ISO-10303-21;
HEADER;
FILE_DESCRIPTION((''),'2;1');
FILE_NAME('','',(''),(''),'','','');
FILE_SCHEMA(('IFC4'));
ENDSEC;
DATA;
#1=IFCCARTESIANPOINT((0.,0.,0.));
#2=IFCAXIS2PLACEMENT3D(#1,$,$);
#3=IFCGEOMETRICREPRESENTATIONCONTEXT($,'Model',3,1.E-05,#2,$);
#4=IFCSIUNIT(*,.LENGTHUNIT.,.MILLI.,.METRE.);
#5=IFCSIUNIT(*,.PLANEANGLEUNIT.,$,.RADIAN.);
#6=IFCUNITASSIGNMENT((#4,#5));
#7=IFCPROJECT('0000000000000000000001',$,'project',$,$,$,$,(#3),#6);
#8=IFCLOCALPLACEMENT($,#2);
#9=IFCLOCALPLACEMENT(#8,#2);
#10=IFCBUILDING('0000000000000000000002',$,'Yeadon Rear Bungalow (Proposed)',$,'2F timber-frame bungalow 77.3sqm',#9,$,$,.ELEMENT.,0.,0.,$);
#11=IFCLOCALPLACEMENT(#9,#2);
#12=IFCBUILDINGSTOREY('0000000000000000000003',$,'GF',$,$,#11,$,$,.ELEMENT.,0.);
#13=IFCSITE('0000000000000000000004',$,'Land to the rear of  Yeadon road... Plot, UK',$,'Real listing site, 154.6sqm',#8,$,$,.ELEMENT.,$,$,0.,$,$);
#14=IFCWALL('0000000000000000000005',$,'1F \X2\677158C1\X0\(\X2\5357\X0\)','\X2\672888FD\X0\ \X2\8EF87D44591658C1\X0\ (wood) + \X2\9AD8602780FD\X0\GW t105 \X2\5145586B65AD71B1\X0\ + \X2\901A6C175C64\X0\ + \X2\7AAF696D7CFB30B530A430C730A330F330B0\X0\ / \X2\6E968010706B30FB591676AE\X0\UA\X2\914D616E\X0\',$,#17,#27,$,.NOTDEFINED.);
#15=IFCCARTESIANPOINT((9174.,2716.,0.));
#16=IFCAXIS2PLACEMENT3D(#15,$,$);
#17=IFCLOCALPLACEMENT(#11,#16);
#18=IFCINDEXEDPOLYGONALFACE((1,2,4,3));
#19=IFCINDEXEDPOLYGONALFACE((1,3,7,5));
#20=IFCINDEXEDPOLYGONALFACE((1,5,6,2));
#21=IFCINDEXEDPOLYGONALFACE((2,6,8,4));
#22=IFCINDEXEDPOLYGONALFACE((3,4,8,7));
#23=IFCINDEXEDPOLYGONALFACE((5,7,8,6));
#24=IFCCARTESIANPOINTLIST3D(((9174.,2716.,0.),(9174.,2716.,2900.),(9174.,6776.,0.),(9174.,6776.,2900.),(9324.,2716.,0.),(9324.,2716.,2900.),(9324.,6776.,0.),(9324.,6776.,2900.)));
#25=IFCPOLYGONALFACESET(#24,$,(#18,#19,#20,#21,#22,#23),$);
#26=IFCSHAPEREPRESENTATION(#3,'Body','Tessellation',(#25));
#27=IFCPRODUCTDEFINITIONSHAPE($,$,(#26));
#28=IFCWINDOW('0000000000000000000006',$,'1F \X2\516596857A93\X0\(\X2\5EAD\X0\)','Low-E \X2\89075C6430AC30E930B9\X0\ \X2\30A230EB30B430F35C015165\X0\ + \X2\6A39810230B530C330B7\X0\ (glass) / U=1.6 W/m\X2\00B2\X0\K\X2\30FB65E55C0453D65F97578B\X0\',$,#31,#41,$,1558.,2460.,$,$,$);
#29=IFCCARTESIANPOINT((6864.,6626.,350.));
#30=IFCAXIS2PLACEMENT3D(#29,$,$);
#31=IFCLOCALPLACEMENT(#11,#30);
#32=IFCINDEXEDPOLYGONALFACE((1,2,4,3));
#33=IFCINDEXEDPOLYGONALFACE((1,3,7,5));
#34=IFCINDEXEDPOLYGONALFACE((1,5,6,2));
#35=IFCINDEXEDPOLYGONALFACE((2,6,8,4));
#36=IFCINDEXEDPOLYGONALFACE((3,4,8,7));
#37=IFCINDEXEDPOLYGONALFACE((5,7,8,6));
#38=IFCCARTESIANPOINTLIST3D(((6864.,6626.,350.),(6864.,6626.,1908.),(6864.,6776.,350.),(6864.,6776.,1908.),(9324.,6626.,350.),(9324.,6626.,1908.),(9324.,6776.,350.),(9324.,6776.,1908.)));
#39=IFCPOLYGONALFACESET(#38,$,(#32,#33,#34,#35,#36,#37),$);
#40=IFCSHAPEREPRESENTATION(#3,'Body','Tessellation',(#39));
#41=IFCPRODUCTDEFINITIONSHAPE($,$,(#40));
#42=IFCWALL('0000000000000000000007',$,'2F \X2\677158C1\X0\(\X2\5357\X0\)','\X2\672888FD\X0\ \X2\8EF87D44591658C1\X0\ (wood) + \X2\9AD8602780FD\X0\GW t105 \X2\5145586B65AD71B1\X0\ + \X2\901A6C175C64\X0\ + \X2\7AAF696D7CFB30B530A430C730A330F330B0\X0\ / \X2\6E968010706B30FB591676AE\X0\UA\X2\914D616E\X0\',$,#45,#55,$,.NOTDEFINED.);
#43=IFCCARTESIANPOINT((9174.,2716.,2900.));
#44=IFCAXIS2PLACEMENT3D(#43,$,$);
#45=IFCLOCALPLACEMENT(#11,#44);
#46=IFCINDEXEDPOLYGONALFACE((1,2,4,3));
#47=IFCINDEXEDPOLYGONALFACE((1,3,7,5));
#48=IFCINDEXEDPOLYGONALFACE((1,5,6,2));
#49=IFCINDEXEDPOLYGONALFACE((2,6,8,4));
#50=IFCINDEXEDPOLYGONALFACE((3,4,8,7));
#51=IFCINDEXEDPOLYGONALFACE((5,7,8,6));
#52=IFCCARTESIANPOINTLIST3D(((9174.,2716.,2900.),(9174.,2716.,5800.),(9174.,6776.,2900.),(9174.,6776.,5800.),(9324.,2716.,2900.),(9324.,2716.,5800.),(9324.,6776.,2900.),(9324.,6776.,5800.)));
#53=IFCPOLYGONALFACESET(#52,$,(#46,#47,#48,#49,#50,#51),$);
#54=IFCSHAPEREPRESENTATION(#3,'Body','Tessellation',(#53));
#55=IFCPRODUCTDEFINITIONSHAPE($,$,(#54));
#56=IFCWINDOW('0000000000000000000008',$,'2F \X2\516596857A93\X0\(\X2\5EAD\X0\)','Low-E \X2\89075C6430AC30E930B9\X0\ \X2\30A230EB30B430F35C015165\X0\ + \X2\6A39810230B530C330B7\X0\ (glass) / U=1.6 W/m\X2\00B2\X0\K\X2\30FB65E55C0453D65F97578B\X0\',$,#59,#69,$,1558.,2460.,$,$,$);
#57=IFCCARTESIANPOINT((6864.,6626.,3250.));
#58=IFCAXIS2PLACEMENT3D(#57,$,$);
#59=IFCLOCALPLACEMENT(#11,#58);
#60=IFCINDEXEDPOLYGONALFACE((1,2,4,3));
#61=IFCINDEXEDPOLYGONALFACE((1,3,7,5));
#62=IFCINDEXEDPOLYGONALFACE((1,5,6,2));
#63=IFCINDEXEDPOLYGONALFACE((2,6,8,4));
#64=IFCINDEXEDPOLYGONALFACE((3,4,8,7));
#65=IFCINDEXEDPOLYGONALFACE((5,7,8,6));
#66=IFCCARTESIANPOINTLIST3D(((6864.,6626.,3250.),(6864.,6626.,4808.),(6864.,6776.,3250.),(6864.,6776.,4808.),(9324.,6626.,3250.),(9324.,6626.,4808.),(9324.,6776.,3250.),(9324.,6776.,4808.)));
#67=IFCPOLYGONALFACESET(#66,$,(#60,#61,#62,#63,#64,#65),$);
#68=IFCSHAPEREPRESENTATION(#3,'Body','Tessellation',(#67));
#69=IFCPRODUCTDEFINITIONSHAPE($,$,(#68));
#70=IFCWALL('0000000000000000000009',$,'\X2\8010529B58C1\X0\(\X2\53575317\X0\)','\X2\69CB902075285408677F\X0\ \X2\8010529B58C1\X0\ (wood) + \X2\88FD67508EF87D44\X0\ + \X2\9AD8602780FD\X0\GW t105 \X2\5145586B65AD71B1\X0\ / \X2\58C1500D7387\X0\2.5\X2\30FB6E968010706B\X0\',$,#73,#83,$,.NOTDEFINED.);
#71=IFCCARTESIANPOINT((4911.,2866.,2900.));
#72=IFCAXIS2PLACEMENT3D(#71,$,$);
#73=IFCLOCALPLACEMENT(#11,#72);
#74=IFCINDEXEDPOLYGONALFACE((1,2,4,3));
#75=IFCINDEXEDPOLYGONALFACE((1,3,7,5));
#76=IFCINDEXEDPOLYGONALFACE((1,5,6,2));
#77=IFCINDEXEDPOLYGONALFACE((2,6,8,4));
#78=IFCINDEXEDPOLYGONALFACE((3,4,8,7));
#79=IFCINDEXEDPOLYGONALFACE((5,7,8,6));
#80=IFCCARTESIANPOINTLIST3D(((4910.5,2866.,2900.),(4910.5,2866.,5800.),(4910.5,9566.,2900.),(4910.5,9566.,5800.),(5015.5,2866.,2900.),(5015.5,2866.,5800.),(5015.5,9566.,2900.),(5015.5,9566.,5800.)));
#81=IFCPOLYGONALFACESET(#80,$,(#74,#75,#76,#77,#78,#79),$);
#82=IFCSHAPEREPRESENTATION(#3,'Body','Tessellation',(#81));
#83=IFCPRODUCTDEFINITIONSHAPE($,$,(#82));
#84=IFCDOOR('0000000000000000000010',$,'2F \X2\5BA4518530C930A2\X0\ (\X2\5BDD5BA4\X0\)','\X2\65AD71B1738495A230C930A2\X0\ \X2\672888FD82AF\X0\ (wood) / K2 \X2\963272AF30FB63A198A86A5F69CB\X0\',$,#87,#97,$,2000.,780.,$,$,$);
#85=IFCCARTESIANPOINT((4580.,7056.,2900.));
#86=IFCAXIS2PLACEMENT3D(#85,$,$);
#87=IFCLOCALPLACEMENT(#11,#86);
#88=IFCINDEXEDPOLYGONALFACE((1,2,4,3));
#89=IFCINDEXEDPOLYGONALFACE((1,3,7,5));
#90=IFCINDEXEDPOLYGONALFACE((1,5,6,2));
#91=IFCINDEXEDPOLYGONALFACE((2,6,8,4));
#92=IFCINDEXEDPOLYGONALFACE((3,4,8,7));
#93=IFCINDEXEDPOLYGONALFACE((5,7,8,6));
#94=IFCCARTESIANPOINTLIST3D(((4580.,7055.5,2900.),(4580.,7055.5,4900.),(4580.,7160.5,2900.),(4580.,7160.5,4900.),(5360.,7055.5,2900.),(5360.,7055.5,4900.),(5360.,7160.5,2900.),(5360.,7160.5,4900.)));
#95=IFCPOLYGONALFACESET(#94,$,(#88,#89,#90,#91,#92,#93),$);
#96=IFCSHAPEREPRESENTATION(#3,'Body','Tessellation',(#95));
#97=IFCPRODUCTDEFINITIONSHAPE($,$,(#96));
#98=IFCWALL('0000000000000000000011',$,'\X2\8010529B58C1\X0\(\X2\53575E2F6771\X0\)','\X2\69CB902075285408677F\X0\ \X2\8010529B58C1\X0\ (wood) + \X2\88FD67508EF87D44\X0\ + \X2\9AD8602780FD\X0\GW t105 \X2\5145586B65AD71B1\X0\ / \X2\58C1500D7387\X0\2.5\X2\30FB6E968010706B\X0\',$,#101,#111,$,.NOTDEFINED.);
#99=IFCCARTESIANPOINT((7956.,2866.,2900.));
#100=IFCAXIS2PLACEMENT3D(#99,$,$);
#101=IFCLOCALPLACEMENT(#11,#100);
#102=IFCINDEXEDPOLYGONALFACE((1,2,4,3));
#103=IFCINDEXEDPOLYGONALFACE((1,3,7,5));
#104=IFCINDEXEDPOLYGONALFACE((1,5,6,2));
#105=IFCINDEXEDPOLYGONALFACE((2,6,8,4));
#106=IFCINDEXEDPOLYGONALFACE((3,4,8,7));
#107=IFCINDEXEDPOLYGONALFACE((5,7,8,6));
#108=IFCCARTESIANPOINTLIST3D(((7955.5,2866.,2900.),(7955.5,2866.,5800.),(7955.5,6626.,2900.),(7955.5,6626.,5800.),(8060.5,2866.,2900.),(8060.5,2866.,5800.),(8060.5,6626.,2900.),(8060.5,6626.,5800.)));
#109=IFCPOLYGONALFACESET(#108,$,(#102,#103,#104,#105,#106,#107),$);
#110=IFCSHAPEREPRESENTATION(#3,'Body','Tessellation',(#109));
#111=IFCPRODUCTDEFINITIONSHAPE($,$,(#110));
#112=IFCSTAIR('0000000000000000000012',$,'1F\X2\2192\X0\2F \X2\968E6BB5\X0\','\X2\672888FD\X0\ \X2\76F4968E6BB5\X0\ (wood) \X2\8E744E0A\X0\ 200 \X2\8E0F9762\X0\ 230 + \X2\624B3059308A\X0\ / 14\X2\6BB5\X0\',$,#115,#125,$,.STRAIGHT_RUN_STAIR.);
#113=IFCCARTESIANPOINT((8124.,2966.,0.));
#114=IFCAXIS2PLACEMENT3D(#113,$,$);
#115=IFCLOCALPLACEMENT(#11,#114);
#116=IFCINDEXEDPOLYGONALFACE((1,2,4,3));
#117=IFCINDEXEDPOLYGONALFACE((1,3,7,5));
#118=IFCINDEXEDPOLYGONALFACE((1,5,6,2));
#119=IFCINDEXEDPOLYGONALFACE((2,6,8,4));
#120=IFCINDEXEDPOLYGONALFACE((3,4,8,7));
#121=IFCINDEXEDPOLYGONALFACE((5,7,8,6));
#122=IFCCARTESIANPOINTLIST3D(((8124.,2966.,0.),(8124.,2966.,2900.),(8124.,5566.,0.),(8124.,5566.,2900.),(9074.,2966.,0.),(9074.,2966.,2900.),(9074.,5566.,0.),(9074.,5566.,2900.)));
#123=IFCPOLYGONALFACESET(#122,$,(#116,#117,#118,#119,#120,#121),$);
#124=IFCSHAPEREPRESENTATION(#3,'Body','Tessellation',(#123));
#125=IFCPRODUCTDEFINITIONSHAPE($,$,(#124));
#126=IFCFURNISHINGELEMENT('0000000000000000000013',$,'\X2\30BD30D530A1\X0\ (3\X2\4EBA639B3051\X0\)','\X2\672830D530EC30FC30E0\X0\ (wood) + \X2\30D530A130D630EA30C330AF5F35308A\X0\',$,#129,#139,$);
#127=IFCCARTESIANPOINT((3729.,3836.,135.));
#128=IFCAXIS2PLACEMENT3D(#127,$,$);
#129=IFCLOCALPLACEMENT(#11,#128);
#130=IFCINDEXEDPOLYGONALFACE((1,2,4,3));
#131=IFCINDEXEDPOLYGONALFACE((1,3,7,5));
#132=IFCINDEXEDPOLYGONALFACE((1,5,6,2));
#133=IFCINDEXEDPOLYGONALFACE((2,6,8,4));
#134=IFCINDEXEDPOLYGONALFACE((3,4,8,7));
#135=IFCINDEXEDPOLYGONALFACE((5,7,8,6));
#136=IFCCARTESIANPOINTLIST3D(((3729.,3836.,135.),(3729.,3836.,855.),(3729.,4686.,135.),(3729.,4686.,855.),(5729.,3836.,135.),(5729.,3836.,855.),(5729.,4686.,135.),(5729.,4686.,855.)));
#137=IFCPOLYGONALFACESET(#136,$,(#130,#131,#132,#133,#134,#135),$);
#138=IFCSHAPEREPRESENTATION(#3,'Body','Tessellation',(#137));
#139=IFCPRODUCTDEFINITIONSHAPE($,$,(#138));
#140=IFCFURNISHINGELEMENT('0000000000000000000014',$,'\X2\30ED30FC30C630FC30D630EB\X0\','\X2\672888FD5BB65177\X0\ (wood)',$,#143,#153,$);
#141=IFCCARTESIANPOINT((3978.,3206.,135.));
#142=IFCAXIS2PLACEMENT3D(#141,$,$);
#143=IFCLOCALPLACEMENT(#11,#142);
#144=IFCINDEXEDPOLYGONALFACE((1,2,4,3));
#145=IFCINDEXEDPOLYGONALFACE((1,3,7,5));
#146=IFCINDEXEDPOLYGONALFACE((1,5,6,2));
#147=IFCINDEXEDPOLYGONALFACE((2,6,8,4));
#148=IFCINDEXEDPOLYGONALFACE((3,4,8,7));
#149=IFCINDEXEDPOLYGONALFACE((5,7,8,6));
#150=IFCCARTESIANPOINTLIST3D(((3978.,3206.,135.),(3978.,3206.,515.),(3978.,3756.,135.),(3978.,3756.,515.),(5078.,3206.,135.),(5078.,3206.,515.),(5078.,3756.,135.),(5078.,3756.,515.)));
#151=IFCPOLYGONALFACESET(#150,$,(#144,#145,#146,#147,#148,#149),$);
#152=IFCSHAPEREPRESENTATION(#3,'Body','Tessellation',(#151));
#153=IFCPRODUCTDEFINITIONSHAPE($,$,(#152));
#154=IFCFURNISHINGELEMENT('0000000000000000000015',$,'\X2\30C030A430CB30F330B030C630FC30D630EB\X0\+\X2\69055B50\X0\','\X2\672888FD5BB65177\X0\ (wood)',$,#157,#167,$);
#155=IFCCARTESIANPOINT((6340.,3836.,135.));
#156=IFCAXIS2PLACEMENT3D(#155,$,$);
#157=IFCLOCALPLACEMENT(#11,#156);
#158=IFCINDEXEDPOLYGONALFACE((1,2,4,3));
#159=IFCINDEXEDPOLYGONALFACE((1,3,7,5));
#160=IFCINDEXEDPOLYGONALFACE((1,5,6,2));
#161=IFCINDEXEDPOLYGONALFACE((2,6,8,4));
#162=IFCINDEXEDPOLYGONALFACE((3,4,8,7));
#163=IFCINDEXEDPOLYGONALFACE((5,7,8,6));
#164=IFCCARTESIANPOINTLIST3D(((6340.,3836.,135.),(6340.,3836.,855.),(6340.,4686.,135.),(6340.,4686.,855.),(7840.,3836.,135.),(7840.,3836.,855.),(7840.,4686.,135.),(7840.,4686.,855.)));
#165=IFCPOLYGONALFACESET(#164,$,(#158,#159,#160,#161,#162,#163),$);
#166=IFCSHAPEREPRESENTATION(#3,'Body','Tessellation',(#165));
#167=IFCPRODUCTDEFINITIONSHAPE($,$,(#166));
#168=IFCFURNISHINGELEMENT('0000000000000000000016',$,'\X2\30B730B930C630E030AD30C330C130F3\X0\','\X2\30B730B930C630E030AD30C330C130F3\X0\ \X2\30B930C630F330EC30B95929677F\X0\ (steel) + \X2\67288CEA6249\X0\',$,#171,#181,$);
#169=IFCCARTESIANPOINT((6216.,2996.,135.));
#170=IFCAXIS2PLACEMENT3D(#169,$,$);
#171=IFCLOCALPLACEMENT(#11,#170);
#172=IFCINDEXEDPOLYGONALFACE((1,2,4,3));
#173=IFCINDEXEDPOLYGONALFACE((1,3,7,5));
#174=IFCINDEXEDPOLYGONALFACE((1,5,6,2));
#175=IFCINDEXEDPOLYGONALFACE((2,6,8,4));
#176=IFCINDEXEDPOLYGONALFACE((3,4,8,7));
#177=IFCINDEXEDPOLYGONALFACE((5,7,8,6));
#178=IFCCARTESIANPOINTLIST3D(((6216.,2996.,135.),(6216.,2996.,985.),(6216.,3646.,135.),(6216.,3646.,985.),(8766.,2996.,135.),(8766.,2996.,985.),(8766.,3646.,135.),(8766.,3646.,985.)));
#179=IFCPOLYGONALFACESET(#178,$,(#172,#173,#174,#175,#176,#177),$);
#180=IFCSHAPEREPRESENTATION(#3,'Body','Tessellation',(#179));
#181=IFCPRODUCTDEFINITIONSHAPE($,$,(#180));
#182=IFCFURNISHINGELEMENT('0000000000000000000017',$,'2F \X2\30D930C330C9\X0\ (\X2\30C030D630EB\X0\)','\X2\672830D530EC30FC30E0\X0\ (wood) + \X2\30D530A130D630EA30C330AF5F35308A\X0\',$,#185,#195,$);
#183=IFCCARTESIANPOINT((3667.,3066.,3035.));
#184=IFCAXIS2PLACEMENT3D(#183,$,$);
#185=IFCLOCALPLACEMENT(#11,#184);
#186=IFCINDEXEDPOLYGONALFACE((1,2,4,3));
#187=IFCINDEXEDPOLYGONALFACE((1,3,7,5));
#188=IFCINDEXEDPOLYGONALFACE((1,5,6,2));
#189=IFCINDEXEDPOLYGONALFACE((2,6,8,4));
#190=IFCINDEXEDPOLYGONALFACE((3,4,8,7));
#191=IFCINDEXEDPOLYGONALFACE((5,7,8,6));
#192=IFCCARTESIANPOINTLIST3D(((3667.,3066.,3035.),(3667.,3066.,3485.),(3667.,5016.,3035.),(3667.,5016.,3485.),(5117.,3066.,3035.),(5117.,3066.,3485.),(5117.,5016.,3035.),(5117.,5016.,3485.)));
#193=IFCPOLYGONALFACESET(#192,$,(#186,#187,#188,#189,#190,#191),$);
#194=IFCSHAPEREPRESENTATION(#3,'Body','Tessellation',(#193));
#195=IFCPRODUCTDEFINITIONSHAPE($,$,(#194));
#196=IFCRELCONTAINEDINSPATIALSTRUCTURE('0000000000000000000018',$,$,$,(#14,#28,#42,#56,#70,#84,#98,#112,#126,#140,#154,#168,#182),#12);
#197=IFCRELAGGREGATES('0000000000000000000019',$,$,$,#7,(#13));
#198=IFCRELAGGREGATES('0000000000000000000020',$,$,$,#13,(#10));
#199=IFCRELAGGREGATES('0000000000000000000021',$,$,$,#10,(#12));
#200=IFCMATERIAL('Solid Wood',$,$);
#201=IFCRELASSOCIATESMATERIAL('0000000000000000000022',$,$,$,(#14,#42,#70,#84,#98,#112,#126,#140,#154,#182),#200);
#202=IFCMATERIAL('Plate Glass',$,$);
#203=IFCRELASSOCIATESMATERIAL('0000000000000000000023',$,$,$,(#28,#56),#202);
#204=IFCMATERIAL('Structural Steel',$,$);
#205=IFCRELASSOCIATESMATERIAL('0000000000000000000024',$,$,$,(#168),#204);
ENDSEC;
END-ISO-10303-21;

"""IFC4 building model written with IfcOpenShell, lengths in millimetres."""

from ifc_helpers import new_model, si_unit, frame, frame_2d, origin, place, context, project, spatial, rectangle, extrude, material, element, fill, save


model = new_model("IFC4")

# Units and contexts
model_context = context("Model", 3, precision=1e-05, world=origin())
ifc_project = project(units=[si_unit("LENGTHUNIT", "METRE", prefix="MILLI"), si_unit("PLANEANGLEUNIT", "RADIAN")], contexts=[model_context])

# Site, building, storey
site_placement = place(None, origin())
site = spatial("IfcSite", under=ifc_project, at=site_placement, Name="Land to the rear of  Yeadon road... Plot, UK", ObjectType="Real listing site, 154.6sqm", CompositionType="ELEMENT", RefElevation=0.0)
building_placement = place(site_placement, origin())
building = spatial("IfcBuilding", under=site, at=building_placement, Name="Yeadon Rear Bungalow (Proposed)", ObjectType="2F timber-frame bungalow 77.3sqm", CompositionType="ELEMENT", ElevationOfRefHeight=0.0, ElevationOfTerrain=0.0)
storey_placement = place(building_placement, origin())
storey = spatial("IfcBuildingStorey", under=building, at=storey_placement, Name="GF", CompositionType="ELEMENT", Elevation=0.0)

# Wall, opening, window
ifc_material_1 = material(Name="Solid Wood")
wall_1_placement = place(storey_placement, frame((9174.0, 2716.0, 0.0)))
wall_1 = element("IfcWall", 1, at=wall_1_placement, inside=storey, material=ifc_material_1, Name="1F 東壁(南)", Description="木製 軸組外壁 (wood) + 高性能GW t105 充填断熱 + 通気層 + 窯業系サイディング / 準耐火・外皮UA配慮", PredefinedType="NOTDEFINED", context=model_context, shape_type="SweptSolid", body=[
    extrude(rectangle(XDim=150.0, YDim=4060.0, at=frame_2d((75.0, 2030.0))), frame((9174.0, 2716.0, 0.0)), (0.0, 0.0, 1.0), 2900.0),
])
opening_1_placement = place(storey_placement, frame((6864.0, 6626.0, 350.0)))
opening_1 = element("IfcOpeningElement", 2, at=opening_1_placement, cuts=wall_1, PredefinedType="NOTDEFINED", context=model_context, shape_type="SweptSolid", body=[
    extrude(rectangle(XDim=2460.0, YDim=150.0, at=frame_2d((1230.0, 75.0))), frame((6864.0, 6626.0, 350.0)), (0.0, 0.0, 1.0), 1558.0),
])
ifc_material_2 = material(Name="Plate Glass")
window_1_placement = place(storey_placement, frame((6864.0, 6626.0, 350.0)))
window_1 = element("IfcWindow", 3, at=window_1_placement, inside=storey, material=ifc_material_2, Name="1F 入隅窓(庭)", Description="Low-E 複層ガラス アルゴン封入 + 樹脂サッシ (glass) / U=1.6 W/m²K・日射取得型", OverallHeight=1558.0, OverallWidth=2460.0, context=model_context, shape_type="SweptSolid", body=[
    extrude(rectangle(XDim=2460.0, YDim=150.0, at=frame_2d((1230.0, 75.0))), frame((6864.0, 6626.0, 350.0)), (0.0, 0.0, 1.0), 1558.0),
])
fill(opening_1, window_1)

# Wall, opening, window
wall_2_placement = place(storey_placement, frame((9174.0, 2716.0, 2900.0)))
wall_2 = element("IfcWall", 4, at=wall_2_placement, inside=storey, material=ifc_material_1, Name="2F 東壁(南)", Description="木製 軸組外壁 (wood) + 高性能GW t105 充填断熱 + 通気層 + 窯業系サイディング / 準耐火・外皮UA配慮", PredefinedType="NOTDEFINED", context=model_context, shape_type="SweptSolid", body=[
    extrude(rectangle(XDim=150.0, YDim=4060.0, at=frame_2d((75.0, 2030.0))), frame((9174.0, 2716.0, 2900.0)), (0.0, 0.0, 1.0), 2900.0),
])
opening_2_placement = place(storey_placement, frame((6864.0, 6626.0, 3250.0)))
opening_2 = element("IfcOpeningElement", 5, at=opening_2_placement, cuts=wall_2, PredefinedType="NOTDEFINED", context=model_context, shape_type="SweptSolid", body=[
    extrude(rectangle(XDim=2460.0, YDim=150.0, at=frame_2d((1230.0, 75.0))), frame((6864.0, 6626.0, 3250.0)), (0.0, 0.0, 1.0), 1558.0),
])
window_2_placement = place(storey_placement, frame((6864.0, 6626.0, 3250.0)))
window_2 = element("IfcWindow", 6, at=window_2_placement, inside=storey, material=ifc_material_2, Name="2F 入隅窓(庭)", Description="Low-E 複層ガラス アルゴン封入 + 樹脂サッシ (glass) / U=1.6 W/m²K・日射取得型", OverallHeight=1558.0, OverallWidth=2460.0, context=model_context, shape_type="SweptSolid", body=[
    extrude(rectangle(XDim=2460.0, YDim=150.0, at=frame_2d((1230.0, 75.0))), frame((6864.0, 6626.0, 3250.0)), (0.0, 0.0, 1.0), 1558.0),
])
fill(opening_2, window_2)

# Wall, opening, door
wall_3_placement = place(storey_placement, frame((4911.0, 2866.0, 2900.0)))
wall_3 = element("IfcWall", 7, at=wall_3_placement, inside=storey, material=ifc_material_1, Name="耐力壁(南北)", Description="構造用合板 耐力壁 (wood) + 製材軸組 + 高性能GW t105 充填断熱 / 壁倍率2.5・準耐火", PredefinedType="NOTDEFINED", context=model_context, shape_type="SweptSolid", body=[
    extrude(rectangle(XDim=105.0, YDim=6700.0, at=frame_2d((52.0, 3350.0))), frame((4911.0, 2866.0, 2900.0)), (0.0, 0.0, 1.0), 2900.0),
])
opening_3_placement = place(storey_placement, frame((4580.0, 7056.0, 2900.0)))
opening_3 = element("IfcOpeningElement", 8, at=opening_3_placement, cuts=wall_3, PredefinedType="NOTDEFINED", context=model_context, shape_type="SweptSolid", body=[
    extrude(rectangle(XDim=780.0, YDim=105.0, at=frame_2d((390.0, 52.0))), frame((4580.0, 7056.0, 2900.0)), (0.0, 0.0, 1.0), 2000.0),
])
door_1_placement = place(storey_placement, frame((4580.0, 7056.0, 2900.0)))
door_1 = element("IfcDoor", 9, at=door_1_placement, inside=storey, material=ifc_material_1, Name="2F 室内ドア (寝室)", Description="断熱玄関ドア 木製芯 (wood) / K2 防犯・採風機構", OverallHeight=2000.0, OverallWidth=780.0, context=model_context, shape_type="SweptSolid", body=[
    extrude(rectangle(XDim=780.0, YDim=105.0, at=frame_2d((390.0, 52.0))), frame((4580.0, 7056.0, 2900.0)), (0.0, 0.0, 1.0), 2000.0),
])
fill(opening_3, door_1)

# Wall
wall_4_placement = place(storey_placement, frame((7956.0, 2866.0, 2900.0)))
element("IfcWall", 10, at=wall_4_placement, inside=storey, material=ifc_material_1, Name="耐力壁(南帯東)", Description="構造用合板 耐力壁 (wood) + 製材軸組 + 高性能GW t105 充填断熱 / 壁倍率2.5・準耐火", PredefinedType="NOTDEFINED", context=model_context, shape_type="SweptSolid", body=[
    extrude(rectangle(XDim=105.0, YDim=3760.0, at=frame_2d((52.0, 1880.0))), frame((7956.0, 2866.0, 2900.0)), (0.0, 0.0, 1.0), 2900.0),
])

# Stair
stair_placement = place(storey_placement, frame((8124.0, 2966.0, 0.0)))
element("IfcStair", 11, at=stair_placement, inside=storey, material=ifc_material_1, Name="1F→2F 階段", Description="木製 直階段 (wood) 蹴上 200 踏面 230 + 手すり / 14段", PredefinedType="STRAIGHT_RUN_STAIR", context=model_context, shape_type="SweptSolid", body=[
    extrude(rectangle(XDim=950.0, YDim=2600.0, at=frame_2d((475.0, 1300.0))), frame((8124.0, 2966.0, 0.0)), (0.0, 0.0, 1.0), 2900.0),
])

# Furnishing elements
furnishing_1_placement = place(storey_placement, frame((3729.0, 3836.0, 135.0)))
element("IfcFurnishingElement", 12, at=furnishing_1_placement, inside=storey, material=ifc_material_1, Name="ソファ (3人掛け)", Description="木フレーム (wood) + ファブリック張り", context=model_context, shape_type="SweptSolid", body=[
    extrude(rectangle(XDim=2000.0, YDim=850.0, at=frame_2d((1000.0, 425.0))), frame((3729.0, 3836.0, 135.0)), (0.0, 0.0, 1.0), 720.0),
])
furnishing_2_placement = place(storey_placement, frame((3978.0, 3206.0, 135.0)))
element("IfcFurnishingElement", 13, at=furnishing_2_placement, inside=storey, material=ifc_material_1, Name="ローテーブル", Description="木製家具 (wood)", context=model_context, shape_type="SweptSolid", body=[
    extrude(rectangle(XDim=1100.0, YDim=550.0, at=frame_2d((550.0, 275.0))), frame((3978.0, 3206.0, 135.0)), (0.0, 0.0, 1.0), 380.0),
])
furnishing_3_placement = place(storey_placement, frame((6340.0, 3836.0, 135.0)))
element("IfcFurnishingElement", 14, at=furnishing_3_placement, inside=storey, material=ifc_material_1, Name="ダイニングテーブル+椅子", Description="木製家具 (wood)", context=model_context, shape_type="SweptSolid", body=[
    extrude(rectangle(XDim=1500.0, YDim=850.0, at=frame_2d((750.0, 425.0))), frame((6340.0, 3836.0, 135.0)), (0.0, 0.0, 1.0), 720.0),
])
ifc_material_3 = material(Name="Structural Steel")
furnishing_4_placement = place(storey_placement, frame((6216.0, 2996.0, 135.0)))
element("IfcFurnishingElement", 15, at=furnishing_4_placement, inside=storey, material=ifc_material_3, Name="システムキッチン", Description="システムキッチン ステンレス天板 (steel) + 木質扉", context=model_context, shape_type="SweptSolid", body=[
    extrude(rectangle(XDim=2550.0, YDim=650.0, at=frame_2d((1275.0, 325.0))), frame((6216.0, 2996.0, 135.0)), (0.0, 0.0, 1.0), 850.0),
])
furnishing_5_placement = place(storey_placement, frame((3667.0, 3066.0, 3035.0)))
element("IfcFurnishingElement", 16, at=furnishing_5_placement, inside=storey, material=ifc_material_1, Name="2F ベッド (ダブル)", Description="木フレーム (wood) + ファブリック張り", context=model_context, shape_type="SweptSolid", body=[
    extrude(rectangle(XDim=1450.0, YDim=1950.0, at=frame_2d((725.0, 975.0))), frame((3667.0, 3066.0, 3035.0)), (0.0, 0.0, 1.0), 450.0),
])

save(model, "model.ifc")
